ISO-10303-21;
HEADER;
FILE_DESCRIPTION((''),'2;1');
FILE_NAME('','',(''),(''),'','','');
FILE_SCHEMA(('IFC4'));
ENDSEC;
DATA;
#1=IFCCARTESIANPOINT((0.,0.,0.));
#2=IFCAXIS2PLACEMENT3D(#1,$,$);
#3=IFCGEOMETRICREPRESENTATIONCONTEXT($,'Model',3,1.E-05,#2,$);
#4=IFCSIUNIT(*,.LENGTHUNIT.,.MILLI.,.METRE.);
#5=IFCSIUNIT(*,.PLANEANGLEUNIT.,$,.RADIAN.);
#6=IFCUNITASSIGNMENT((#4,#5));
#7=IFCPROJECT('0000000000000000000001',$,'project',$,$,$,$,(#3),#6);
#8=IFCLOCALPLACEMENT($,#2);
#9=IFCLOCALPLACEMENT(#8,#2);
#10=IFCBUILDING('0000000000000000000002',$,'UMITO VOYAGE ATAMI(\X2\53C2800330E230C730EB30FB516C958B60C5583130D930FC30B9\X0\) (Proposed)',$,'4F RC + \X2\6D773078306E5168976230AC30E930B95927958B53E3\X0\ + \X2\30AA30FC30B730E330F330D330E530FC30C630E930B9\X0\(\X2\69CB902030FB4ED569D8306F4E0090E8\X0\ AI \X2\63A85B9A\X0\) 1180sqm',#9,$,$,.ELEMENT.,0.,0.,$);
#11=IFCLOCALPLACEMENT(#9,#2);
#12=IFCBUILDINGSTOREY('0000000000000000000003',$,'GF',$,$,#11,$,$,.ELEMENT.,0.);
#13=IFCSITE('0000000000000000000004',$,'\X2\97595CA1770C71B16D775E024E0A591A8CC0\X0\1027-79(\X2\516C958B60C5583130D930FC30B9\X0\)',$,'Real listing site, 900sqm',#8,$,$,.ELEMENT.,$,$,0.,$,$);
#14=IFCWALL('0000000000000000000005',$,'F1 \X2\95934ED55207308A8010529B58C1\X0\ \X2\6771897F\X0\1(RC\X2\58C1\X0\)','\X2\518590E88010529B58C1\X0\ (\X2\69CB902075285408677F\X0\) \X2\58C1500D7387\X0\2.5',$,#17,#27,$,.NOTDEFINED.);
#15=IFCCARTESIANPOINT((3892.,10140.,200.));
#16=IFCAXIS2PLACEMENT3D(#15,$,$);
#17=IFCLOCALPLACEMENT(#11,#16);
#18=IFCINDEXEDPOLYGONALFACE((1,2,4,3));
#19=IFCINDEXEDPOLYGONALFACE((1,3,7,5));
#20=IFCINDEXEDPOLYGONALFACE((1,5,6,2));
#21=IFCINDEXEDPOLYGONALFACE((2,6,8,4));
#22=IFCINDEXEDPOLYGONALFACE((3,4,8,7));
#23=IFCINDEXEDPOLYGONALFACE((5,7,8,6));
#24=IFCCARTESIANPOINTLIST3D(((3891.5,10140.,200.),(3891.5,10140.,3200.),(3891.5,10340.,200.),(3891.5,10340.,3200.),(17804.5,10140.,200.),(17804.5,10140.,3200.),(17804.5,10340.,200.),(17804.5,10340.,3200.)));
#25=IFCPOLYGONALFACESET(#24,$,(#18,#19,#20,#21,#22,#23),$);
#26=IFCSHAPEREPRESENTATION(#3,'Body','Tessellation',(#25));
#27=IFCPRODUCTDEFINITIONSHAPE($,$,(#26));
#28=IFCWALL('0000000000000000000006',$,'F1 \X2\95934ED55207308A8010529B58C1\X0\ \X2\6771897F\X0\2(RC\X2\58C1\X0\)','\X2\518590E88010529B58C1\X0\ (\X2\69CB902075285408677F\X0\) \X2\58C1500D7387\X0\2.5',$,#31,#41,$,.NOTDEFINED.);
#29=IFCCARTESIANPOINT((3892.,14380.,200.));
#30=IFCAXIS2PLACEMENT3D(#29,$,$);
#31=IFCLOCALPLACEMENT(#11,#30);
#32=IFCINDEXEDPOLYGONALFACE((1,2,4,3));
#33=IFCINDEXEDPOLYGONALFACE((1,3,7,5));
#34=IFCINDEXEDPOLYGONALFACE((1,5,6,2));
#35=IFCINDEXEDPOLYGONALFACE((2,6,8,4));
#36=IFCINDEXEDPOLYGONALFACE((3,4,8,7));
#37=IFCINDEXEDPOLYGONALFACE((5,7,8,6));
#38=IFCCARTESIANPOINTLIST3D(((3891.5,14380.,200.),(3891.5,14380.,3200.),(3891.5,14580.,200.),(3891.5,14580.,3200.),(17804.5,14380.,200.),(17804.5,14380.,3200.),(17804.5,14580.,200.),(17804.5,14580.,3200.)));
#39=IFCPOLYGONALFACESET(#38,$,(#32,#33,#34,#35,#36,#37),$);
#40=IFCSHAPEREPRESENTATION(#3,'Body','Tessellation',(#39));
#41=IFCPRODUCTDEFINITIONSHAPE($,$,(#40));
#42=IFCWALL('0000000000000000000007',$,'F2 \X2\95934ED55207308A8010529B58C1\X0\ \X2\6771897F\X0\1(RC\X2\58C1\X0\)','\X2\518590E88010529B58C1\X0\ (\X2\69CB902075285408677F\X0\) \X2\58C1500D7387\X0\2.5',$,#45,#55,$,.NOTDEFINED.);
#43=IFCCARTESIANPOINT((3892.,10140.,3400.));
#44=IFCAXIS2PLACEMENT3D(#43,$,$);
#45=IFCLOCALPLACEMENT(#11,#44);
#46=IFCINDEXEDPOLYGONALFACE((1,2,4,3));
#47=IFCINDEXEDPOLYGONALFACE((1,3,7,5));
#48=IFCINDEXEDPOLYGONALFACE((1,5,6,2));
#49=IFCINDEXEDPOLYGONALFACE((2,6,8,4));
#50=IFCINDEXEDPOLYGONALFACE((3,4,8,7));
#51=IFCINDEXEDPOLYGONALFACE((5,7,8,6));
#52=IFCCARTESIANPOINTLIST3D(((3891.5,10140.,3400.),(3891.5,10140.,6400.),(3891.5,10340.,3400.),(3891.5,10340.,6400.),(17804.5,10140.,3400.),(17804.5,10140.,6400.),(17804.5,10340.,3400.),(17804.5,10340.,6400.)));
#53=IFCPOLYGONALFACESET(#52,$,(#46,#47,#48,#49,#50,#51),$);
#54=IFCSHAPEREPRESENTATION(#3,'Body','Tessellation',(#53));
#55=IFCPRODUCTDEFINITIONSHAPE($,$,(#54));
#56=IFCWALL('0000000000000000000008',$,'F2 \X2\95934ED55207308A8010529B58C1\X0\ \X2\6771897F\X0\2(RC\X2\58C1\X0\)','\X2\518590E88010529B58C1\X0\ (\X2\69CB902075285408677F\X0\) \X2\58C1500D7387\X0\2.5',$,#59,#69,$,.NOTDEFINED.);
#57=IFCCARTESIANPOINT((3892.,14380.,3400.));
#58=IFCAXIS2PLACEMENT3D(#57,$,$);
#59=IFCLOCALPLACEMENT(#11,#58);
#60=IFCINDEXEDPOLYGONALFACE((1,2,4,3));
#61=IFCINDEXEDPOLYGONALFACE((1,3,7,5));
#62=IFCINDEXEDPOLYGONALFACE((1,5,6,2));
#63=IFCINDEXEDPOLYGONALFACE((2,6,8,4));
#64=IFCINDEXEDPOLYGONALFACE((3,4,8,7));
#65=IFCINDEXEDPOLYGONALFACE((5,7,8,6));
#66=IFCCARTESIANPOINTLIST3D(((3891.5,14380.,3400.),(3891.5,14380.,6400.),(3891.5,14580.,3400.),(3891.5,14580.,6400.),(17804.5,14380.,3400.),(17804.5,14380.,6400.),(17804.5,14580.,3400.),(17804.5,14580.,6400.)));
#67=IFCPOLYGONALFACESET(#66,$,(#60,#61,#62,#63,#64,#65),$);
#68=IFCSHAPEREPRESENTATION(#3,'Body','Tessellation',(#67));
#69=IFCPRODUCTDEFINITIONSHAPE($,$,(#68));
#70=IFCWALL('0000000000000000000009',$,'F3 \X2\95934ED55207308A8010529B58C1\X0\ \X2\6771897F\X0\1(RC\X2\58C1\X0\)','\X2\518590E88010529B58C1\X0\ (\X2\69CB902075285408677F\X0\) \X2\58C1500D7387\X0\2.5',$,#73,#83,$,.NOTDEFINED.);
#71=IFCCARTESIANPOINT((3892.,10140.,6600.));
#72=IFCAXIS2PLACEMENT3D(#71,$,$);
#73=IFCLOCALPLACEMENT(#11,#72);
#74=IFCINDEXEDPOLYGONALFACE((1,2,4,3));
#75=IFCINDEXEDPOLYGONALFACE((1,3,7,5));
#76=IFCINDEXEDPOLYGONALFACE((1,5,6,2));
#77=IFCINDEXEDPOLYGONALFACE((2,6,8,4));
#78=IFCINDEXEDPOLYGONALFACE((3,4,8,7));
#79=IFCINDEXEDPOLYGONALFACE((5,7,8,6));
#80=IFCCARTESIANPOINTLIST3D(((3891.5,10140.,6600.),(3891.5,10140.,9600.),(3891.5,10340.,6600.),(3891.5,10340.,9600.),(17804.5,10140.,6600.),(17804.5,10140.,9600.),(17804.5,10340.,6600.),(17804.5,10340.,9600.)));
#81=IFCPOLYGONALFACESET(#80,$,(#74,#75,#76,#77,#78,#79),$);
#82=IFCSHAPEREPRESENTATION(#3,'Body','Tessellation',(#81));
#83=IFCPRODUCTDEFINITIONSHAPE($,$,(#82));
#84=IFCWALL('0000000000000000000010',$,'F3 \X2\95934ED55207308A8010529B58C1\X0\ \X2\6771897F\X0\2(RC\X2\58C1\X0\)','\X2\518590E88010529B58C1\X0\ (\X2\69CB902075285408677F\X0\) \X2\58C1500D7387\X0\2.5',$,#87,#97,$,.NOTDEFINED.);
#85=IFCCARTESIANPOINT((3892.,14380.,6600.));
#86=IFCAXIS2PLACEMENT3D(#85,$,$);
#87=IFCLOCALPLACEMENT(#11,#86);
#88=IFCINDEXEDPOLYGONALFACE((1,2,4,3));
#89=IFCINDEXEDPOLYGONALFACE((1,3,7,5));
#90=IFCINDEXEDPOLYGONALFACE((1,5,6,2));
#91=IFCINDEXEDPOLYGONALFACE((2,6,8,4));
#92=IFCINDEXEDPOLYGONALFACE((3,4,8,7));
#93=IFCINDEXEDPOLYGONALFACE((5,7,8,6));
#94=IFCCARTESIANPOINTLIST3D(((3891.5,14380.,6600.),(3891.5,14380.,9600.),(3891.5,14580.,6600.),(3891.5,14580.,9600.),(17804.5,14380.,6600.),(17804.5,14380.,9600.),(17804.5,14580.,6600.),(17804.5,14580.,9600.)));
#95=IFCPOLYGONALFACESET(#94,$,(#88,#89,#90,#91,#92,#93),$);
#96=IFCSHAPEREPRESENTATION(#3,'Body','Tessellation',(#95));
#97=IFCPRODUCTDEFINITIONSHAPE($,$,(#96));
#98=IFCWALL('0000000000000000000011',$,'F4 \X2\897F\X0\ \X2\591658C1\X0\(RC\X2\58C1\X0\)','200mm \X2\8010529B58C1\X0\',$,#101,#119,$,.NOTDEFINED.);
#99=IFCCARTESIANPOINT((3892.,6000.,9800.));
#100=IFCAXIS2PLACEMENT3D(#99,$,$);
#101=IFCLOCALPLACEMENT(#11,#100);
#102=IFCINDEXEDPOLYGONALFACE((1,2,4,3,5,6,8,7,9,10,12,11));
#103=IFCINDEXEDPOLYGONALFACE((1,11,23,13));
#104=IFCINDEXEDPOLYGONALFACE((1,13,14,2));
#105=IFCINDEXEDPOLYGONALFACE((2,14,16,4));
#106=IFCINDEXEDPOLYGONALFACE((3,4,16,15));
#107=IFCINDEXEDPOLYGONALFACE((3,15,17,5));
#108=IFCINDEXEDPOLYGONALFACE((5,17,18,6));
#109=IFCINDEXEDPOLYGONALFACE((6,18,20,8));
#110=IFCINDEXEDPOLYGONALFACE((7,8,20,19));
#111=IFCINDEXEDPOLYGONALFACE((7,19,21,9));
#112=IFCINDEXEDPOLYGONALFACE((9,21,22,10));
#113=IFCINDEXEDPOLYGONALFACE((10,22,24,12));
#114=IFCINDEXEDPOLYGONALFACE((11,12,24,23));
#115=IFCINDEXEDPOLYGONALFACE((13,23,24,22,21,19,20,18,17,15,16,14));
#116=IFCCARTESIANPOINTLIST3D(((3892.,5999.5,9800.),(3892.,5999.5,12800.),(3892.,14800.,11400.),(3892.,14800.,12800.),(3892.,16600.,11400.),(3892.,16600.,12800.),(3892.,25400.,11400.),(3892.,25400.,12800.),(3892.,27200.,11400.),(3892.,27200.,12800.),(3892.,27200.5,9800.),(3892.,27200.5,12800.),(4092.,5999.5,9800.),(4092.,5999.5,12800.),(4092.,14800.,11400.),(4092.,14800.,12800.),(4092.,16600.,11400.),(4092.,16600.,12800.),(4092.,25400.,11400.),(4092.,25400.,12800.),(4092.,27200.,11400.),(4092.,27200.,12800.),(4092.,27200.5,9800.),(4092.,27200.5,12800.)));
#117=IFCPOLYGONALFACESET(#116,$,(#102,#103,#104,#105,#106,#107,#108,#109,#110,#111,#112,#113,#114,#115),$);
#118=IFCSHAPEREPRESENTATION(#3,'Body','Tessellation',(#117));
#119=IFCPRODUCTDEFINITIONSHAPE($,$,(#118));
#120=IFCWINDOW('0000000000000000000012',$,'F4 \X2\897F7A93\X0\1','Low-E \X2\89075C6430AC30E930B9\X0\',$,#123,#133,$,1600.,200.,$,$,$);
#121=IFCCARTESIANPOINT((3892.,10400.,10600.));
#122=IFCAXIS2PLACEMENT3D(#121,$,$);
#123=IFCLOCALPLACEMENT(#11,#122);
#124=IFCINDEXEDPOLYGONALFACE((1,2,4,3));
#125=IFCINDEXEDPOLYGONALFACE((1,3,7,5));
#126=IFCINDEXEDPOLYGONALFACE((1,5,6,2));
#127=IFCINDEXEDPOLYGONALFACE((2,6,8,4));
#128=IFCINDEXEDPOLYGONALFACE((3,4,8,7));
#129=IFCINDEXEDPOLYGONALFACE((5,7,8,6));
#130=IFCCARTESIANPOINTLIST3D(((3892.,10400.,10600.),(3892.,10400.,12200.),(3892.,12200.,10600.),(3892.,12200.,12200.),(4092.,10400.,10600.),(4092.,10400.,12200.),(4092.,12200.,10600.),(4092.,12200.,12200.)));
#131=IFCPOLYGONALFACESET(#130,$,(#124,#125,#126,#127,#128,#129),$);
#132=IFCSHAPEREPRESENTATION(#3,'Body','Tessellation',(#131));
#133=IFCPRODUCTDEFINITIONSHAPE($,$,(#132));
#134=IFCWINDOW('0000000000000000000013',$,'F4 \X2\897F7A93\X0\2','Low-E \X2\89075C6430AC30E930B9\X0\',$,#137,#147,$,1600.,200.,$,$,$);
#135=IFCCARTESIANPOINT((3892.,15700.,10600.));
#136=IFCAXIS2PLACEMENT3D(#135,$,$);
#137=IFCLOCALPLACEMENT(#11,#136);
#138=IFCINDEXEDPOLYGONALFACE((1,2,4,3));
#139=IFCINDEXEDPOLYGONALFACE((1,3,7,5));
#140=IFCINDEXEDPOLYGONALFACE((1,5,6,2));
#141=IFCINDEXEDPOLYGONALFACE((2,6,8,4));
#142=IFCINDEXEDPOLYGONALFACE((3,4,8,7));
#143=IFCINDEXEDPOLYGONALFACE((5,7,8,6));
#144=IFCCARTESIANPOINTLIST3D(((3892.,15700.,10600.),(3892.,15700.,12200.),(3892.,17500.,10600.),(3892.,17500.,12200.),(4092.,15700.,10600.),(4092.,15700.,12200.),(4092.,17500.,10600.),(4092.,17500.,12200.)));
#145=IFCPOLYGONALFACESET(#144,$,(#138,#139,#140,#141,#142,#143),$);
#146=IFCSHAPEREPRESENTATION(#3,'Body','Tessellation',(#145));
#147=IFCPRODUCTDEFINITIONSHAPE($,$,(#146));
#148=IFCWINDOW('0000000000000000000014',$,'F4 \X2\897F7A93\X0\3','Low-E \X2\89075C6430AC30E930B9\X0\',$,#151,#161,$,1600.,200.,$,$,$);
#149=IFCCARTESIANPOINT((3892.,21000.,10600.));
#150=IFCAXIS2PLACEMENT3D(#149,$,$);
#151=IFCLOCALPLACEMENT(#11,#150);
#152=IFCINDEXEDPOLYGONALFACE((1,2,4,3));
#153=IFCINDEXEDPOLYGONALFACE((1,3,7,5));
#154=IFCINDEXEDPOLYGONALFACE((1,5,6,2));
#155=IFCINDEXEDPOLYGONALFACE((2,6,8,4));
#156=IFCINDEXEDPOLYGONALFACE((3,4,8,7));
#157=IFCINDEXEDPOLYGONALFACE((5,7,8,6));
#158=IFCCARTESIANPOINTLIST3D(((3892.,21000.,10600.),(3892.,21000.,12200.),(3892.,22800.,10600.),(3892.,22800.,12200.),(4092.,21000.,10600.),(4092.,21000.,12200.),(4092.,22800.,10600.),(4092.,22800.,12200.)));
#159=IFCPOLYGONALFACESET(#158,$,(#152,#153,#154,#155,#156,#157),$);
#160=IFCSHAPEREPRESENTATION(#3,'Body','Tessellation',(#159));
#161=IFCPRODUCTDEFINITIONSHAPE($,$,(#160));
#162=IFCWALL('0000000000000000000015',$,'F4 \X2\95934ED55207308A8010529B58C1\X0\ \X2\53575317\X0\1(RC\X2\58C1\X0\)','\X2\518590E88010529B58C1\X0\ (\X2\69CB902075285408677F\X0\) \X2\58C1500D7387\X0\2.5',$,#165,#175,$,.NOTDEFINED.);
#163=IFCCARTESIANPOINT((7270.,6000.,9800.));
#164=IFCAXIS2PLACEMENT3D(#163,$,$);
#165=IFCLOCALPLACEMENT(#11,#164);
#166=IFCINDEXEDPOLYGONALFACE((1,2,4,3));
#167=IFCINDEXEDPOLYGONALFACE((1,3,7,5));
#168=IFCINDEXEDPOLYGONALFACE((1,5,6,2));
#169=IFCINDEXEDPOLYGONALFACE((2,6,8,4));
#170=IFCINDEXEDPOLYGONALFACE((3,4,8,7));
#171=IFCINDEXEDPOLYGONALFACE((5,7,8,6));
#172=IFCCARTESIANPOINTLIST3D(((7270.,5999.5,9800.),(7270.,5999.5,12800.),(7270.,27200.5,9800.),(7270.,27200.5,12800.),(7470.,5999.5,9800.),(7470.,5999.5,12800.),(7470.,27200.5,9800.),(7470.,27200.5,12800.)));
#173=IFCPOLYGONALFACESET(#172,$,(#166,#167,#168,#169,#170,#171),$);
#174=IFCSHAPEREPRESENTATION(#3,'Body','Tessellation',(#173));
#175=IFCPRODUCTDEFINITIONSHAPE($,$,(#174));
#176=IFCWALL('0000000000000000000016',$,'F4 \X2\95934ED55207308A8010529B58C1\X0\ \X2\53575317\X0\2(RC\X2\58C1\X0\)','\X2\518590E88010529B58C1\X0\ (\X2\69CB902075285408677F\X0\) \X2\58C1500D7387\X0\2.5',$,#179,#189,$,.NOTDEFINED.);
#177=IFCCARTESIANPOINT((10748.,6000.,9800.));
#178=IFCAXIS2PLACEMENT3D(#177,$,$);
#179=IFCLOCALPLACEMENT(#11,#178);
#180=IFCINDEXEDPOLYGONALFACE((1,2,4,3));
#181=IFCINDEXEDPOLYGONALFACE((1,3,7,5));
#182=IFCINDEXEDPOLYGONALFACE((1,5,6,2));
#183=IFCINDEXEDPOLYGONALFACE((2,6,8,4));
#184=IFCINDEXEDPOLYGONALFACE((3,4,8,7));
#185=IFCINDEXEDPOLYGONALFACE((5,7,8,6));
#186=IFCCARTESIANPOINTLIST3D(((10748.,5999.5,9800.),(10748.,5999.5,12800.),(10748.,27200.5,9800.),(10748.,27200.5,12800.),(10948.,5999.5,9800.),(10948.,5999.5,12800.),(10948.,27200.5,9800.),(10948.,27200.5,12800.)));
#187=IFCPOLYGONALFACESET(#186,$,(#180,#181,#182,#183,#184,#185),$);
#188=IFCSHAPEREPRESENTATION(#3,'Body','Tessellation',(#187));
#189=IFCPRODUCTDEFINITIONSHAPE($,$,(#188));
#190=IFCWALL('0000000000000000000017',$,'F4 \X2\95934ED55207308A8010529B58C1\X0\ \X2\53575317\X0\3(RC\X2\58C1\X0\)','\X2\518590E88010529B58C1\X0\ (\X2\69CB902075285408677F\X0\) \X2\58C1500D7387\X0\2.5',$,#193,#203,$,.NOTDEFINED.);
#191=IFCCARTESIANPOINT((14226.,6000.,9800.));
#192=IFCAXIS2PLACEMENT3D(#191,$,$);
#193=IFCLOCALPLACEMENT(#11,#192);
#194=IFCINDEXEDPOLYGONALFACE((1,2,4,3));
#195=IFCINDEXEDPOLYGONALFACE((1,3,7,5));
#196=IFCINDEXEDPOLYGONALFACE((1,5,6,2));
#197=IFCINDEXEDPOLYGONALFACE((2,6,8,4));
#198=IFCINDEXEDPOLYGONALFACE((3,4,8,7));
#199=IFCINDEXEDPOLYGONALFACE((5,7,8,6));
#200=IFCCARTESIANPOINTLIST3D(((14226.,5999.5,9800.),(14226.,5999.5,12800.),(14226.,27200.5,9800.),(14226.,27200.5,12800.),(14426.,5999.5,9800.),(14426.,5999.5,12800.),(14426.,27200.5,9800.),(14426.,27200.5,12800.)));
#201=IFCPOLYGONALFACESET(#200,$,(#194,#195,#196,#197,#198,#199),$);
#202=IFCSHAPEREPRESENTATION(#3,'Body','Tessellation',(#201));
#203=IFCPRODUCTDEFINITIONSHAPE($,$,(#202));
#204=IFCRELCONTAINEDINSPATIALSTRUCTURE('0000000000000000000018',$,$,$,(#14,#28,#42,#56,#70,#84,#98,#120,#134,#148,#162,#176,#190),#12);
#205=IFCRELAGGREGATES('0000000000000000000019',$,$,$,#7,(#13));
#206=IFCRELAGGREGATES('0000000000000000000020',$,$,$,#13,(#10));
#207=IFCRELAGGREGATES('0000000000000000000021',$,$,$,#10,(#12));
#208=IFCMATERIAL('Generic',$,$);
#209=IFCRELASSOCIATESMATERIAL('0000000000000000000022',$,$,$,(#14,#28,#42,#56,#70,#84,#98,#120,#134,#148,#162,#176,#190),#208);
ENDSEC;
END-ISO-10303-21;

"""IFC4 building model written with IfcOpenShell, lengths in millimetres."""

from ifc_helpers import new_model, si_unit, frame, frame_2d, origin, place, context, project, spatial, rectangle, extrude, material, element, fill, save


model = new_model("IFC4")

# Units and contexts
model_context = context("Model", 3, precision=1e-05, world=origin())
ifc_project = project(units=[si_unit("LENGTHUNIT", "METRE", prefix="MILLI"), si_unit("PLANEANGLEUNIT", "RADIAN")], contexts=[model_context])

# Site, building, storey
site_placement = place(None, origin())
site = spatial("IfcSite", under=ifc_project, at=site_placement, Name="静岡県熱海市上多賀1027-79(公開情報ベース)", ObjectType="Real listing site, 900sqm", CompositionType="ELEMENT", RefElevation=0.0)
building_placement = place(site_placement, origin())
building = spatial("IfcBuilding", under=site, at=building_placement, Name="UMITO VOYAGE ATAMI(参考モデル・公開情報ベース) (Proposed)", ObjectType="4F RC + 海への全面ガラス大開口 + オーシャンビューテラス(構造・仕様は一部 AI 推定) 1180sqm", CompositionType="ELEMENT", ElevationOfRefHeight=0.0, ElevationOfTerrain=0.0)
storey_placement = place(building_placement, origin())
storey = spatial("IfcBuildingStorey", under=building, at=storey_placement, Name="GF", CompositionType="ELEMENT", Elevation=0.0)

# Walls
ifc_material_1 = material(Name="Generic")
wall_1_placement = place(storey_placement, frame((3892.0, 10140.0, 200.0)))
element("IfcWall", 1, at=wall_1_placement, inside=storey, material=ifc_material_1, Name="F1 間仕切り耐力壁 東西1(RC壁)", Description="内部耐力壁 (構造用合板) 壁倍率2.5", PredefinedType="NOTDEFINED", context=model_context, shape_type="SweptSolid", body=[
    extrude(rectangle(XDim=13913.0, YDim=200.0, at=frame_2d((6956.0, 100.0))), frame((3892.0, 10140.0, 200.0)), (0.0, 0.0, 1.0), 3000.0),
])
wall_2_placement = place(storey_placement, frame((3892.0, 14380.0, 200.0)))
element("IfcWall", 2, at=wall_2_placement, inside=storey, material=ifc_material_1, Name="F1 間仕切り耐力壁 東西2(RC壁)", Description="内部耐力壁 (構造用合板) 壁倍率2.5", PredefinedType="NOTDEFINED", context=model_context, shape_type="SweptSolid", body=[
    extrude(rectangle(XDim=13913.0, YDim=200.0, at=frame_2d((6956.0, 100.0))), frame((3892.0, 14380.0, 200.0)), (0.0, 0.0, 1.0), 3000.0),
])
wall_3_placement = place(storey_placement, frame((3892.0, 10140.0, 3400.0)))
element("IfcWall", 3, at=wall_3_placement, inside=storey, material=ifc_material_1, Name="F2 間仕切り耐力壁 東西1(RC壁)", Description="内部耐力壁 (構造用合板) 壁倍率2.5", PredefinedType="NOTDEFINED", context=model_context, shape_type="SweptSolid", body=[
    extrude(rectangle(XDim=13913.0, YDim=200.0, at=frame_2d((6956.0, 100.0))), frame((3892.0, 10140.0, 3400.0)), (0.0, 0.0, 1.0), 3000.0),
])
wall_4_placement = place(storey_placement, frame((3892.0, 14380.0, 3400.0)))
element("IfcWall", 4, at=wall_4_placement, inside=storey, material=ifc_material_1, Name="F2 間仕切り耐力壁 東西2(RC壁)", Description="内部耐力壁 (構造用合板) 壁倍率2.5", PredefinedType="NOTDEFINED", context=model_context, shape_type="SweptSolid", body=[
    extrude(rectangle(XDim=13913.0, YDim=200.0, at=frame_2d((6956.0, 100.0))), frame((3892.0, 14380.0, 3400.0)), (0.0, 0.0, 1.0), 3000.0),
])
wall_5_placement = place(storey_placement, frame((3892.0, 10140.0, 6600.0)))
element("IfcWall", 5, at=wall_5_placement, inside=storey, material=ifc_material_1, Name="F3 間仕切り耐力壁 東西1(RC壁)", Description="内部耐力壁 (構造用合板) 壁倍率2.5", PredefinedType="NOTDEFINED", context=model_context, shape_type="SweptSolid", body=[
    extrude(rectangle(XDim=13913.0, YDim=200.0, at=frame_2d((6956.0, 100.0))), frame((3892.0, 10140.0, 6600.0)), (0.0, 0.0, 1.0), 3000.0),
])
wall_6_placement = place(storey_placement, frame((3892.0, 14380.0, 6600.0)))
element("IfcWall", 6, at=wall_6_placement, inside=storey, material=ifc_material_1, Name="F3 間仕切り耐力壁 東西2(RC壁)", Description="内部耐力壁 (構造用合板) 壁倍率2.5", PredefinedType="NOTDEFINED", context=model_context, shape_type="SweptSolid", body=[
    extrude(rectangle(XDim=13913.0, YDim=200.0, at=frame_2d((6956.0, 100.0))), frame((3892.0, 14380.0, 6600.0)), (0.0, 0.0, 1.0), 3000.0),
])

# Wall, openings, windows
wall_7_placement = place(storey_placement, frame((3892.0, 6000.0, 9800.0)))
wall_7 = element("IfcWall", 7, at=wall_7_placement, inside=storey, material=ifc_material_1, Name="F4 西 外壁(RC壁)", Description="200mm 耐力壁", PredefinedType="NOTDEFINED", context=model_context, shape_type="SweptSolid", body=[
    extrude(rectangle(XDim=200.0, YDim=21201.0, at=frame_2d((100.0, 10600.0))), frame((3892.0, 6000.0, 9800.0)), (0.0, 0.0, 1.0), 3000.0),
])
opening_1_placement = place(storey_placement, frame((3892.0, 10400.0, 10600.0)))
opening_1 = element("IfcOpeningElement", 8, at=opening_1_placement, cuts=wall_7, PredefinedType="NOTDEFINED", context=model_context, shape_type="SweptSolid", body=[
    extrude(rectangle(XDim=200.0, YDim=1800.0, at=frame_2d((100.0, 900.0))), frame((3892.0, 10400.0, 10600.0)), (0.0, 0.0, 1.0), 1600.0),
])
opening_2_placement = place(storey_placement, frame((3892.0, 15700.0, 10600.0)))
opening_2 = element("IfcOpeningElement", 9, at=opening_2_placement, cuts=wall_7, PredefinedType="NOTDEFINED", context=model_context, shape_type="SweptSolid", body=[
    extrude(rectangle(XDim=200.0, YDim=1800.0, at=frame_2d((100.0, 900.0))), frame((3892.0, 15700.0, 10600.0)), (0.0, 0.0, 1.0), 1600.0),
])
opening_3_placement = place(storey_placement, frame((3892.0, 21000.0, 10600.0)))
opening_3 = element("IfcOpeningElement", 10, at=opening_3_placement, cuts=wall_7, PredefinedType="NOTDEFINED", context=model_context, shape_type="SweptSolid", body=[
    extrude(rectangle(XDim=200.0, YDim=1800.0, at=frame_2d((100.0, 900.0))), frame((3892.0, 21000.0, 10600.0)), (0.0, 0.0, 1.0), 1600.0),
])
window_1_placement = place(storey_placement, frame((3892.0, 10400.0, 10600.0)))
window_1 = element("IfcWindow", 11, at=window_1_placement, inside=storey, material=ifc_material_1, Name="F4 西窓1", Description="Low-E 複層ガラス", OverallHeight=1600.0, OverallWidth=200.0, context=model_context, shape_type="SweptSolid", body=[
    extrude(rectangle(XDim=200.0, YDim=1800.0, at=frame_2d((100.0, 900.0))), frame((3892.0, 10400.0, 10600.0)), (0.0, 0.0, 1.0), 1600.0),
])
fill(opening_1, window_1)
window_2_placement = place(storey_placement, frame((3892.0, 15700.0, 10600.0)))
window_2 = element("IfcWindow", 12, at=window_2_placement, inside=storey, material=ifc_material_1, Name="F4 西窓2", Description="Low-E 複層ガラス", OverallHeight=1600.0, OverallWidth=200.0, context=model_context, shape_type="SweptSolid", body=[
    extrude(rectangle(XDim=200.0, YDim=1800.0, at=frame_2d((100.0, 900.0))), frame((3892.0, 15700.0, 10600.0)), (0.0, 0.0, 1.0), 1600.0),
])
fill(opening_2, window_2)
window_3_placement = place(storey_placement, frame((3892.0, 21000.0, 10600.0)))
window_3 = element("IfcWindow", 13, at=window_3_placement, inside=storey, material=ifc_material_1, Name="F4 西窓3", Description="Low-E 複層ガラス", OverallHeight=1600.0, OverallWidth=200.0, context=model_context, shape_type="SweptSolid", body=[
    extrude(rectangle(XDim=200.0, YDim=1800.0, at=frame_2d((100.0, 900.0))), frame((3892.0, 21000.0, 10600.0)), (0.0, 0.0, 1.0), 1600.0),
])
fill(opening_3, window_3)

# Walls
wall_8_placement = place(storey_placement, frame((7270.0, 6000.0, 9800.0)))
element("IfcWall", 14, at=wall_8_placement, inside=storey, material=ifc_material_1, Name="F4 間仕切り耐力壁 南北1(RC壁)", Description="内部耐力壁 (構造用合板) 壁倍率2.5", PredefinedType="NOTDEFINED", context=model_context, shape_type="SweptSolid", body=[
    extrude(rectangle(XDim=200.0, YDim=21201.0, at=frame_2d((100.0, 10600.0))), frame((7270.0, 6000.0, 9800.0)), (0.0, 0.0, 1.0), 3000.0),
])
wall_9_placement = place(storey_placement, frame((10748.0, 6000.0, 9800.0)))
element("IfcWall", 15, at=wall_9_placement, inside=storey, material=ifc_material_1, Name="F4 間仕切り耐力壁 南北2(RC壁)", Description="内部耐力壁 (構造用合板) 壁倍率2.5", PredefinedType="NOTDEFINED", context=model_context, shape_type="SweptSolid", body=[
    extrude(rectangle(XDim=200.0, YDim=21201.0, at=frame_2d((100.0, 10600.0))), frame((10748.0, 6000.0, 9800.0)), (0.0, 0.0, 1.0), 3000.0),
])
wall_10_placement = place(storey_placement, frame((14226.0, 6000.0, 9800.0)))
element("IfcWall", 16, at=wall_10_placement, inside=storey, material=ifc_material_1, Name="F4 間仕切り耐力壁 南北3(RC壁)", Description="内部耐力壁 (構造用合板) 壁倍率2.5", PredefinedType="NOTDEFINED", context=model_context, shape_type="SweptSolid", body=[
    extrude(rectangle(XDim=200.0, YDim=21201.0, at=frame_2d((100.0, 10600.0))), frame((14226.0, 6000.0, 9800.0)), (0.0, 0.0, 1.0), 3000.0),
])

save(model, "model.ifc")
